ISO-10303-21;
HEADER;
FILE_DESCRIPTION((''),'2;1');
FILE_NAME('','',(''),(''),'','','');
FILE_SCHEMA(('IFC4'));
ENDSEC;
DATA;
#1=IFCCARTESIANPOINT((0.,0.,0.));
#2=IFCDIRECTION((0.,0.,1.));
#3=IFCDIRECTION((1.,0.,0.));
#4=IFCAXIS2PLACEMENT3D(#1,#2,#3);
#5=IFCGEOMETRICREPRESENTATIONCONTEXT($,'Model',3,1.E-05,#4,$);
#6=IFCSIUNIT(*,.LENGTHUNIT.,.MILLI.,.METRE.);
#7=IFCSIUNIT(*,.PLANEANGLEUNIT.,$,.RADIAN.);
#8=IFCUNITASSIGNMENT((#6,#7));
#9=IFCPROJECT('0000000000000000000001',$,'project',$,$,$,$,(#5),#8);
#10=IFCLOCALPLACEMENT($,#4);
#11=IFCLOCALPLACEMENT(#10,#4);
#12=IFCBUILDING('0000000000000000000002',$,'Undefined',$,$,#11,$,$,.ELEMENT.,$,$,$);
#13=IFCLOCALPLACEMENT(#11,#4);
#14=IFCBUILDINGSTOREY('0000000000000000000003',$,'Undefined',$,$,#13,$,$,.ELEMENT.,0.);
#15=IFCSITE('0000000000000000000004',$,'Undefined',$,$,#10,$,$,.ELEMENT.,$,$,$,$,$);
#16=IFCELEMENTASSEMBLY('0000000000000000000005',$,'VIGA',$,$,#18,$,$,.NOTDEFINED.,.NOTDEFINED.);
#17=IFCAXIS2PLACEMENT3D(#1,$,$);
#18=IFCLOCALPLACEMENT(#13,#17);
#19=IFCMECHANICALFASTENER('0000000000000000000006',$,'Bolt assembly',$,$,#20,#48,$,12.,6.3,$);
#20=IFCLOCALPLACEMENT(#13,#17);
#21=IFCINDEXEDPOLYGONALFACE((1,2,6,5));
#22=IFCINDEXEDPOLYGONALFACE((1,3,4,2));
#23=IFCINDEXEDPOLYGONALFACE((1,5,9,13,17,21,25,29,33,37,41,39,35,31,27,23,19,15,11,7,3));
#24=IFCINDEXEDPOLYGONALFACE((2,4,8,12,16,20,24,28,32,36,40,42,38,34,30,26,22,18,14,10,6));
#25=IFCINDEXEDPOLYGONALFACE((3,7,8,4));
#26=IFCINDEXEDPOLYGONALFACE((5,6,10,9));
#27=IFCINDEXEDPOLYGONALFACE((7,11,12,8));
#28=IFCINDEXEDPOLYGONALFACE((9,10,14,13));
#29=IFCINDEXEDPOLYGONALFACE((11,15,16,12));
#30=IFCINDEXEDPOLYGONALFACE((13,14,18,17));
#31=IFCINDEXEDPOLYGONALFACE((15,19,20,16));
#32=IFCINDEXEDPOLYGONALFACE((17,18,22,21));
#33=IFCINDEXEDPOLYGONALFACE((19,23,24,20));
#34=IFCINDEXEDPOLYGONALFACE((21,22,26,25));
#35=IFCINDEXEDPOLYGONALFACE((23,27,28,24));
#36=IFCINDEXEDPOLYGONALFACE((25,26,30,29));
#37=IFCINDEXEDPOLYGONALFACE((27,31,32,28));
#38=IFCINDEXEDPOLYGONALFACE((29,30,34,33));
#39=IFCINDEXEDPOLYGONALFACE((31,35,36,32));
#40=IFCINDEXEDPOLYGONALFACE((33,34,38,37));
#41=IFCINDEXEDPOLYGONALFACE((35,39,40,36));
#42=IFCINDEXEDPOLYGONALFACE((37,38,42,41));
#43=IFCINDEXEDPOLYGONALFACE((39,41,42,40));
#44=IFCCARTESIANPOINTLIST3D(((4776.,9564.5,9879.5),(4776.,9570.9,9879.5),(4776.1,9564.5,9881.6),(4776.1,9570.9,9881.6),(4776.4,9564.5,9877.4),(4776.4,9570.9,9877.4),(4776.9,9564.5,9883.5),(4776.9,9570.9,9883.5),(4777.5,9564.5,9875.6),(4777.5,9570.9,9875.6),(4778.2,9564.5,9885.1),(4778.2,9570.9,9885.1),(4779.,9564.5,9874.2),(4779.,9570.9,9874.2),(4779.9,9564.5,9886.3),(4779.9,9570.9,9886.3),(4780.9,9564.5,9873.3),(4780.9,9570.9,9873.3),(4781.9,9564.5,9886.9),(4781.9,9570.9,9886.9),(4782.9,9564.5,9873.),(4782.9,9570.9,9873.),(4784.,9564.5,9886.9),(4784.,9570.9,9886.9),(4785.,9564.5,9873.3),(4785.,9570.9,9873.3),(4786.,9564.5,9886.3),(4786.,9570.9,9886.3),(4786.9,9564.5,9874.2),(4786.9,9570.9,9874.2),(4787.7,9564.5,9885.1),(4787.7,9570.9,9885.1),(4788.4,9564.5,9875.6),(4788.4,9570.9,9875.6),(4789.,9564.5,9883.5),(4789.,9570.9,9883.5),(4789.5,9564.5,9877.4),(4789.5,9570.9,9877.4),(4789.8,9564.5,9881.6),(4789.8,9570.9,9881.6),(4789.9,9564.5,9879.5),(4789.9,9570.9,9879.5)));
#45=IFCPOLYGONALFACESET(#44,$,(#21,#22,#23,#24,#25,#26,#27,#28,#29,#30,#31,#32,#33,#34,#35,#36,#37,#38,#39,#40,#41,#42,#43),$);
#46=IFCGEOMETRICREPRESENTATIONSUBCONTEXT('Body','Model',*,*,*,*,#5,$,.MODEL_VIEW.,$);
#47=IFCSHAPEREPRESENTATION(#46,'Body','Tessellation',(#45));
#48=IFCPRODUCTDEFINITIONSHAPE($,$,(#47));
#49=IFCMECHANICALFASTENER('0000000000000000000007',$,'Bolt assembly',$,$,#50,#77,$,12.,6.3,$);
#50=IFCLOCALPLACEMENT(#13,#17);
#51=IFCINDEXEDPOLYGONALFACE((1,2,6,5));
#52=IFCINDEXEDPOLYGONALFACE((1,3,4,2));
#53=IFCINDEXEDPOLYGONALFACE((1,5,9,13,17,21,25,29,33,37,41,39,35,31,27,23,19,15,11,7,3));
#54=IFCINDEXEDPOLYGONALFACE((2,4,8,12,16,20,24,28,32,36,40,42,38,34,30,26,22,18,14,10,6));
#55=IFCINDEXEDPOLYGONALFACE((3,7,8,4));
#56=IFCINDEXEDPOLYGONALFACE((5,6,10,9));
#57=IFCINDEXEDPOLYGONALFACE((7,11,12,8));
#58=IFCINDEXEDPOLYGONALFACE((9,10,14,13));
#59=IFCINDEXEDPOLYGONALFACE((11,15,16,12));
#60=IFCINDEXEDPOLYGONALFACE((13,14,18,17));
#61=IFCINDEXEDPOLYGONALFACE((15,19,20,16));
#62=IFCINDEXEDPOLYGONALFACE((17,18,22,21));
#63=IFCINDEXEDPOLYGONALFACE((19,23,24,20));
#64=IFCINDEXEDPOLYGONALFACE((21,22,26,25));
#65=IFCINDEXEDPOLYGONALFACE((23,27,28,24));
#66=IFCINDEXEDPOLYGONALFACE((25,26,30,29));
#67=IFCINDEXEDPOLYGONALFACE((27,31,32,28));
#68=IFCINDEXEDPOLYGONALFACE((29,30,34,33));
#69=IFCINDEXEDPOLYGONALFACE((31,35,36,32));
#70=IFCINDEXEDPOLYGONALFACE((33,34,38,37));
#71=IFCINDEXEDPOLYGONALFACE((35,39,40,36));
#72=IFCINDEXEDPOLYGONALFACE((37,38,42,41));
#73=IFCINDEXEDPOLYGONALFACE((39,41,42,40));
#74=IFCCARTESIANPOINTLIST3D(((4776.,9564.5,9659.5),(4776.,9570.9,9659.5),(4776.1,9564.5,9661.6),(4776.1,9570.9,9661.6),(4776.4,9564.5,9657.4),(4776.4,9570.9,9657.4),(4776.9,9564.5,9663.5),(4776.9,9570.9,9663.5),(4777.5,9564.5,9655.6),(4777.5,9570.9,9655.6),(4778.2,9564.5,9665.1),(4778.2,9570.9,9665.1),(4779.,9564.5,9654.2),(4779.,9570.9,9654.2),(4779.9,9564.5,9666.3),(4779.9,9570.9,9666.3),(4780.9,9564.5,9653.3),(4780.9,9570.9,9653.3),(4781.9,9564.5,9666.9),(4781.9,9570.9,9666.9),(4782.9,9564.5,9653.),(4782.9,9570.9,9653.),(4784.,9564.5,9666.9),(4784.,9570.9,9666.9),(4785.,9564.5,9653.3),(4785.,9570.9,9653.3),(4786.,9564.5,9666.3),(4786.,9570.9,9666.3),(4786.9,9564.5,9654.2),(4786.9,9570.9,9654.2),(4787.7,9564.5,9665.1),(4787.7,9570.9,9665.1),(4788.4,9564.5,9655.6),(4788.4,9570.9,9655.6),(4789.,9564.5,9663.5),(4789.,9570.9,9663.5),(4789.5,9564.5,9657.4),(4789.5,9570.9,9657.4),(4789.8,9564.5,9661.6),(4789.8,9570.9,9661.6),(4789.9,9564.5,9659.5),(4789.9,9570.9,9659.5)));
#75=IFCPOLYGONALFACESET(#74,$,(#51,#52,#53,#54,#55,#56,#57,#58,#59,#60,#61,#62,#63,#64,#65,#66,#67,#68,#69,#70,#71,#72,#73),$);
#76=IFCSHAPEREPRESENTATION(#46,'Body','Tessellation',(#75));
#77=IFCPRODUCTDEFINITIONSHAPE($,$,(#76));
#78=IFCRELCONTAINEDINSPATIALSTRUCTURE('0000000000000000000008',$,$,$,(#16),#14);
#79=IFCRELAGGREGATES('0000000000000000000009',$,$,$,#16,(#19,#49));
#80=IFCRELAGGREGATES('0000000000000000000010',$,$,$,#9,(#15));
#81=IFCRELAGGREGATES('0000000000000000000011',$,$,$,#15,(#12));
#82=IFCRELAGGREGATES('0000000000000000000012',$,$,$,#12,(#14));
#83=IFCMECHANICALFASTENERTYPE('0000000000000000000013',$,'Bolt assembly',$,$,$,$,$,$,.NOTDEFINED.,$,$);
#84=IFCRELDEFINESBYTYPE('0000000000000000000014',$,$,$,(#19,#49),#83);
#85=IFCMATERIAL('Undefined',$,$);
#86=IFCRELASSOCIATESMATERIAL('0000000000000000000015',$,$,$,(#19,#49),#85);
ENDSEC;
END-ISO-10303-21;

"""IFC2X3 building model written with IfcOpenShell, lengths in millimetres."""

from ifc_helpers import new_model, si_unit, frame, origin_with_axes, origin_2d_with_axis, place, context, subcontext, project, spatial, circle, extrude, source, transform, mapped, material, type_object, element, aggregate, save


model = new_model("IFC2X3")

# Units and contexts
model_context = context("Model", 3, precision=1e-05, world=origin_with_axes())
body_context = subcontext(model_context, "Body", "Model", "MODEL_VIEW")
ifc_project = project(units=[si_unit("LENGTHUNIT", "METRE", prefix="MILLI"), si_unit("PLANEANGLEUNIT", "RADIAN")], contexts=[model_context])

# Site, building, storey
site_placement = place(None, origin_with_axes())
site = spatial("IfcSite", under=ifc_project, at=site_placement, Name="Undefined", CompositionType="ELEMENT")
building_placement = place(site_placement, origin_with_axes())
building = spatial("IfcBuilding", under=site, at=building_placement, Name="Undefined", CompositionType="ELEMENT")
storey_placement = place(building_placement, origin_with_axes())
storey = spatial("IfcBuildingStorey", under=building, at=storey_placement, Name="Undefined", CompositionType="ELEMENT", Elevation=0.0)

# Element assembly
assembly_1_placement = place(storey_placement, origin_with_axes())
assembly_1 = element("IfcElementAssembly", 1, at=assembly_1_placement, inside=storey, Name="VIGA", AssemblyPlace="NOTDEFINED", PredefinedType="NOTDEFINED")

# Shared definitions
ifc_material_1 = material(Name="Undefined")
mechanical_fastener_type = type_object("IfcMechanicalFastenerType", Name="Bolt assembly")

# Mechanical fasteners
shared_shape_1 = source(origin_with_axes(), body_context, "Body", "SweptSolid", [
    extrude(circle(Radius=7.0, at=origin_2d_with_axis()), frame((0.0, -6.4, 0.0), z_axis=(0.0, 1.0, 0.0), x_axis=(1.0, 0.0, 0.0)), (0.0, 0.0, 1.0), 6.5),
])
mechanical_fastener_1_placement = place(assembly_1_placement, frame((4782.9, 9570.8, 9880.0), z_axis=(1.0, 0.0, 0.0), x_axis=(0.0, 0.0, -1.0)))
mechanical_fastener_1 = element("IfcMechanicalFastener", 2, at=mechanical_fastener_1_placement, type_object=mechanical_fastener_type, material=ifc_material_1, Name="Bolt assembly", NominalDiameter=12.0, NominalLength=6.3, context=body_context, shape_type="MappedRepresentation", body=[
    mapped(shared_shape_1, transform((0.0, 0.0, 0.0))),
])
mechanical_fastener_2_placement = place(assembly_1_placement, frame((4782.9, 9570.8, 9660.0), z_axis=(1.0, 0.0, 0.0), x_axis=(0.0, 0.0, -1.0)))
mechanical_fastener_2 = element("IfcMechanicalFastener", 3, at=mechanical_fastener_2_placement, type_object=mechanical_fastener_type, material=ifc_material_1, Name="Bolt assembly", NominalDiameter=12.0, NominalLength=6.3, context=body_context, shape_type="MappedRepresentation", body=[
    mapped(shared_shape_1, transform((0.0, 0.0, 0.0))),
])
aggregate(assembly_1, [mechanical_fastener_1, mechanical_fastener_2])

save(model, "model.ifc")
